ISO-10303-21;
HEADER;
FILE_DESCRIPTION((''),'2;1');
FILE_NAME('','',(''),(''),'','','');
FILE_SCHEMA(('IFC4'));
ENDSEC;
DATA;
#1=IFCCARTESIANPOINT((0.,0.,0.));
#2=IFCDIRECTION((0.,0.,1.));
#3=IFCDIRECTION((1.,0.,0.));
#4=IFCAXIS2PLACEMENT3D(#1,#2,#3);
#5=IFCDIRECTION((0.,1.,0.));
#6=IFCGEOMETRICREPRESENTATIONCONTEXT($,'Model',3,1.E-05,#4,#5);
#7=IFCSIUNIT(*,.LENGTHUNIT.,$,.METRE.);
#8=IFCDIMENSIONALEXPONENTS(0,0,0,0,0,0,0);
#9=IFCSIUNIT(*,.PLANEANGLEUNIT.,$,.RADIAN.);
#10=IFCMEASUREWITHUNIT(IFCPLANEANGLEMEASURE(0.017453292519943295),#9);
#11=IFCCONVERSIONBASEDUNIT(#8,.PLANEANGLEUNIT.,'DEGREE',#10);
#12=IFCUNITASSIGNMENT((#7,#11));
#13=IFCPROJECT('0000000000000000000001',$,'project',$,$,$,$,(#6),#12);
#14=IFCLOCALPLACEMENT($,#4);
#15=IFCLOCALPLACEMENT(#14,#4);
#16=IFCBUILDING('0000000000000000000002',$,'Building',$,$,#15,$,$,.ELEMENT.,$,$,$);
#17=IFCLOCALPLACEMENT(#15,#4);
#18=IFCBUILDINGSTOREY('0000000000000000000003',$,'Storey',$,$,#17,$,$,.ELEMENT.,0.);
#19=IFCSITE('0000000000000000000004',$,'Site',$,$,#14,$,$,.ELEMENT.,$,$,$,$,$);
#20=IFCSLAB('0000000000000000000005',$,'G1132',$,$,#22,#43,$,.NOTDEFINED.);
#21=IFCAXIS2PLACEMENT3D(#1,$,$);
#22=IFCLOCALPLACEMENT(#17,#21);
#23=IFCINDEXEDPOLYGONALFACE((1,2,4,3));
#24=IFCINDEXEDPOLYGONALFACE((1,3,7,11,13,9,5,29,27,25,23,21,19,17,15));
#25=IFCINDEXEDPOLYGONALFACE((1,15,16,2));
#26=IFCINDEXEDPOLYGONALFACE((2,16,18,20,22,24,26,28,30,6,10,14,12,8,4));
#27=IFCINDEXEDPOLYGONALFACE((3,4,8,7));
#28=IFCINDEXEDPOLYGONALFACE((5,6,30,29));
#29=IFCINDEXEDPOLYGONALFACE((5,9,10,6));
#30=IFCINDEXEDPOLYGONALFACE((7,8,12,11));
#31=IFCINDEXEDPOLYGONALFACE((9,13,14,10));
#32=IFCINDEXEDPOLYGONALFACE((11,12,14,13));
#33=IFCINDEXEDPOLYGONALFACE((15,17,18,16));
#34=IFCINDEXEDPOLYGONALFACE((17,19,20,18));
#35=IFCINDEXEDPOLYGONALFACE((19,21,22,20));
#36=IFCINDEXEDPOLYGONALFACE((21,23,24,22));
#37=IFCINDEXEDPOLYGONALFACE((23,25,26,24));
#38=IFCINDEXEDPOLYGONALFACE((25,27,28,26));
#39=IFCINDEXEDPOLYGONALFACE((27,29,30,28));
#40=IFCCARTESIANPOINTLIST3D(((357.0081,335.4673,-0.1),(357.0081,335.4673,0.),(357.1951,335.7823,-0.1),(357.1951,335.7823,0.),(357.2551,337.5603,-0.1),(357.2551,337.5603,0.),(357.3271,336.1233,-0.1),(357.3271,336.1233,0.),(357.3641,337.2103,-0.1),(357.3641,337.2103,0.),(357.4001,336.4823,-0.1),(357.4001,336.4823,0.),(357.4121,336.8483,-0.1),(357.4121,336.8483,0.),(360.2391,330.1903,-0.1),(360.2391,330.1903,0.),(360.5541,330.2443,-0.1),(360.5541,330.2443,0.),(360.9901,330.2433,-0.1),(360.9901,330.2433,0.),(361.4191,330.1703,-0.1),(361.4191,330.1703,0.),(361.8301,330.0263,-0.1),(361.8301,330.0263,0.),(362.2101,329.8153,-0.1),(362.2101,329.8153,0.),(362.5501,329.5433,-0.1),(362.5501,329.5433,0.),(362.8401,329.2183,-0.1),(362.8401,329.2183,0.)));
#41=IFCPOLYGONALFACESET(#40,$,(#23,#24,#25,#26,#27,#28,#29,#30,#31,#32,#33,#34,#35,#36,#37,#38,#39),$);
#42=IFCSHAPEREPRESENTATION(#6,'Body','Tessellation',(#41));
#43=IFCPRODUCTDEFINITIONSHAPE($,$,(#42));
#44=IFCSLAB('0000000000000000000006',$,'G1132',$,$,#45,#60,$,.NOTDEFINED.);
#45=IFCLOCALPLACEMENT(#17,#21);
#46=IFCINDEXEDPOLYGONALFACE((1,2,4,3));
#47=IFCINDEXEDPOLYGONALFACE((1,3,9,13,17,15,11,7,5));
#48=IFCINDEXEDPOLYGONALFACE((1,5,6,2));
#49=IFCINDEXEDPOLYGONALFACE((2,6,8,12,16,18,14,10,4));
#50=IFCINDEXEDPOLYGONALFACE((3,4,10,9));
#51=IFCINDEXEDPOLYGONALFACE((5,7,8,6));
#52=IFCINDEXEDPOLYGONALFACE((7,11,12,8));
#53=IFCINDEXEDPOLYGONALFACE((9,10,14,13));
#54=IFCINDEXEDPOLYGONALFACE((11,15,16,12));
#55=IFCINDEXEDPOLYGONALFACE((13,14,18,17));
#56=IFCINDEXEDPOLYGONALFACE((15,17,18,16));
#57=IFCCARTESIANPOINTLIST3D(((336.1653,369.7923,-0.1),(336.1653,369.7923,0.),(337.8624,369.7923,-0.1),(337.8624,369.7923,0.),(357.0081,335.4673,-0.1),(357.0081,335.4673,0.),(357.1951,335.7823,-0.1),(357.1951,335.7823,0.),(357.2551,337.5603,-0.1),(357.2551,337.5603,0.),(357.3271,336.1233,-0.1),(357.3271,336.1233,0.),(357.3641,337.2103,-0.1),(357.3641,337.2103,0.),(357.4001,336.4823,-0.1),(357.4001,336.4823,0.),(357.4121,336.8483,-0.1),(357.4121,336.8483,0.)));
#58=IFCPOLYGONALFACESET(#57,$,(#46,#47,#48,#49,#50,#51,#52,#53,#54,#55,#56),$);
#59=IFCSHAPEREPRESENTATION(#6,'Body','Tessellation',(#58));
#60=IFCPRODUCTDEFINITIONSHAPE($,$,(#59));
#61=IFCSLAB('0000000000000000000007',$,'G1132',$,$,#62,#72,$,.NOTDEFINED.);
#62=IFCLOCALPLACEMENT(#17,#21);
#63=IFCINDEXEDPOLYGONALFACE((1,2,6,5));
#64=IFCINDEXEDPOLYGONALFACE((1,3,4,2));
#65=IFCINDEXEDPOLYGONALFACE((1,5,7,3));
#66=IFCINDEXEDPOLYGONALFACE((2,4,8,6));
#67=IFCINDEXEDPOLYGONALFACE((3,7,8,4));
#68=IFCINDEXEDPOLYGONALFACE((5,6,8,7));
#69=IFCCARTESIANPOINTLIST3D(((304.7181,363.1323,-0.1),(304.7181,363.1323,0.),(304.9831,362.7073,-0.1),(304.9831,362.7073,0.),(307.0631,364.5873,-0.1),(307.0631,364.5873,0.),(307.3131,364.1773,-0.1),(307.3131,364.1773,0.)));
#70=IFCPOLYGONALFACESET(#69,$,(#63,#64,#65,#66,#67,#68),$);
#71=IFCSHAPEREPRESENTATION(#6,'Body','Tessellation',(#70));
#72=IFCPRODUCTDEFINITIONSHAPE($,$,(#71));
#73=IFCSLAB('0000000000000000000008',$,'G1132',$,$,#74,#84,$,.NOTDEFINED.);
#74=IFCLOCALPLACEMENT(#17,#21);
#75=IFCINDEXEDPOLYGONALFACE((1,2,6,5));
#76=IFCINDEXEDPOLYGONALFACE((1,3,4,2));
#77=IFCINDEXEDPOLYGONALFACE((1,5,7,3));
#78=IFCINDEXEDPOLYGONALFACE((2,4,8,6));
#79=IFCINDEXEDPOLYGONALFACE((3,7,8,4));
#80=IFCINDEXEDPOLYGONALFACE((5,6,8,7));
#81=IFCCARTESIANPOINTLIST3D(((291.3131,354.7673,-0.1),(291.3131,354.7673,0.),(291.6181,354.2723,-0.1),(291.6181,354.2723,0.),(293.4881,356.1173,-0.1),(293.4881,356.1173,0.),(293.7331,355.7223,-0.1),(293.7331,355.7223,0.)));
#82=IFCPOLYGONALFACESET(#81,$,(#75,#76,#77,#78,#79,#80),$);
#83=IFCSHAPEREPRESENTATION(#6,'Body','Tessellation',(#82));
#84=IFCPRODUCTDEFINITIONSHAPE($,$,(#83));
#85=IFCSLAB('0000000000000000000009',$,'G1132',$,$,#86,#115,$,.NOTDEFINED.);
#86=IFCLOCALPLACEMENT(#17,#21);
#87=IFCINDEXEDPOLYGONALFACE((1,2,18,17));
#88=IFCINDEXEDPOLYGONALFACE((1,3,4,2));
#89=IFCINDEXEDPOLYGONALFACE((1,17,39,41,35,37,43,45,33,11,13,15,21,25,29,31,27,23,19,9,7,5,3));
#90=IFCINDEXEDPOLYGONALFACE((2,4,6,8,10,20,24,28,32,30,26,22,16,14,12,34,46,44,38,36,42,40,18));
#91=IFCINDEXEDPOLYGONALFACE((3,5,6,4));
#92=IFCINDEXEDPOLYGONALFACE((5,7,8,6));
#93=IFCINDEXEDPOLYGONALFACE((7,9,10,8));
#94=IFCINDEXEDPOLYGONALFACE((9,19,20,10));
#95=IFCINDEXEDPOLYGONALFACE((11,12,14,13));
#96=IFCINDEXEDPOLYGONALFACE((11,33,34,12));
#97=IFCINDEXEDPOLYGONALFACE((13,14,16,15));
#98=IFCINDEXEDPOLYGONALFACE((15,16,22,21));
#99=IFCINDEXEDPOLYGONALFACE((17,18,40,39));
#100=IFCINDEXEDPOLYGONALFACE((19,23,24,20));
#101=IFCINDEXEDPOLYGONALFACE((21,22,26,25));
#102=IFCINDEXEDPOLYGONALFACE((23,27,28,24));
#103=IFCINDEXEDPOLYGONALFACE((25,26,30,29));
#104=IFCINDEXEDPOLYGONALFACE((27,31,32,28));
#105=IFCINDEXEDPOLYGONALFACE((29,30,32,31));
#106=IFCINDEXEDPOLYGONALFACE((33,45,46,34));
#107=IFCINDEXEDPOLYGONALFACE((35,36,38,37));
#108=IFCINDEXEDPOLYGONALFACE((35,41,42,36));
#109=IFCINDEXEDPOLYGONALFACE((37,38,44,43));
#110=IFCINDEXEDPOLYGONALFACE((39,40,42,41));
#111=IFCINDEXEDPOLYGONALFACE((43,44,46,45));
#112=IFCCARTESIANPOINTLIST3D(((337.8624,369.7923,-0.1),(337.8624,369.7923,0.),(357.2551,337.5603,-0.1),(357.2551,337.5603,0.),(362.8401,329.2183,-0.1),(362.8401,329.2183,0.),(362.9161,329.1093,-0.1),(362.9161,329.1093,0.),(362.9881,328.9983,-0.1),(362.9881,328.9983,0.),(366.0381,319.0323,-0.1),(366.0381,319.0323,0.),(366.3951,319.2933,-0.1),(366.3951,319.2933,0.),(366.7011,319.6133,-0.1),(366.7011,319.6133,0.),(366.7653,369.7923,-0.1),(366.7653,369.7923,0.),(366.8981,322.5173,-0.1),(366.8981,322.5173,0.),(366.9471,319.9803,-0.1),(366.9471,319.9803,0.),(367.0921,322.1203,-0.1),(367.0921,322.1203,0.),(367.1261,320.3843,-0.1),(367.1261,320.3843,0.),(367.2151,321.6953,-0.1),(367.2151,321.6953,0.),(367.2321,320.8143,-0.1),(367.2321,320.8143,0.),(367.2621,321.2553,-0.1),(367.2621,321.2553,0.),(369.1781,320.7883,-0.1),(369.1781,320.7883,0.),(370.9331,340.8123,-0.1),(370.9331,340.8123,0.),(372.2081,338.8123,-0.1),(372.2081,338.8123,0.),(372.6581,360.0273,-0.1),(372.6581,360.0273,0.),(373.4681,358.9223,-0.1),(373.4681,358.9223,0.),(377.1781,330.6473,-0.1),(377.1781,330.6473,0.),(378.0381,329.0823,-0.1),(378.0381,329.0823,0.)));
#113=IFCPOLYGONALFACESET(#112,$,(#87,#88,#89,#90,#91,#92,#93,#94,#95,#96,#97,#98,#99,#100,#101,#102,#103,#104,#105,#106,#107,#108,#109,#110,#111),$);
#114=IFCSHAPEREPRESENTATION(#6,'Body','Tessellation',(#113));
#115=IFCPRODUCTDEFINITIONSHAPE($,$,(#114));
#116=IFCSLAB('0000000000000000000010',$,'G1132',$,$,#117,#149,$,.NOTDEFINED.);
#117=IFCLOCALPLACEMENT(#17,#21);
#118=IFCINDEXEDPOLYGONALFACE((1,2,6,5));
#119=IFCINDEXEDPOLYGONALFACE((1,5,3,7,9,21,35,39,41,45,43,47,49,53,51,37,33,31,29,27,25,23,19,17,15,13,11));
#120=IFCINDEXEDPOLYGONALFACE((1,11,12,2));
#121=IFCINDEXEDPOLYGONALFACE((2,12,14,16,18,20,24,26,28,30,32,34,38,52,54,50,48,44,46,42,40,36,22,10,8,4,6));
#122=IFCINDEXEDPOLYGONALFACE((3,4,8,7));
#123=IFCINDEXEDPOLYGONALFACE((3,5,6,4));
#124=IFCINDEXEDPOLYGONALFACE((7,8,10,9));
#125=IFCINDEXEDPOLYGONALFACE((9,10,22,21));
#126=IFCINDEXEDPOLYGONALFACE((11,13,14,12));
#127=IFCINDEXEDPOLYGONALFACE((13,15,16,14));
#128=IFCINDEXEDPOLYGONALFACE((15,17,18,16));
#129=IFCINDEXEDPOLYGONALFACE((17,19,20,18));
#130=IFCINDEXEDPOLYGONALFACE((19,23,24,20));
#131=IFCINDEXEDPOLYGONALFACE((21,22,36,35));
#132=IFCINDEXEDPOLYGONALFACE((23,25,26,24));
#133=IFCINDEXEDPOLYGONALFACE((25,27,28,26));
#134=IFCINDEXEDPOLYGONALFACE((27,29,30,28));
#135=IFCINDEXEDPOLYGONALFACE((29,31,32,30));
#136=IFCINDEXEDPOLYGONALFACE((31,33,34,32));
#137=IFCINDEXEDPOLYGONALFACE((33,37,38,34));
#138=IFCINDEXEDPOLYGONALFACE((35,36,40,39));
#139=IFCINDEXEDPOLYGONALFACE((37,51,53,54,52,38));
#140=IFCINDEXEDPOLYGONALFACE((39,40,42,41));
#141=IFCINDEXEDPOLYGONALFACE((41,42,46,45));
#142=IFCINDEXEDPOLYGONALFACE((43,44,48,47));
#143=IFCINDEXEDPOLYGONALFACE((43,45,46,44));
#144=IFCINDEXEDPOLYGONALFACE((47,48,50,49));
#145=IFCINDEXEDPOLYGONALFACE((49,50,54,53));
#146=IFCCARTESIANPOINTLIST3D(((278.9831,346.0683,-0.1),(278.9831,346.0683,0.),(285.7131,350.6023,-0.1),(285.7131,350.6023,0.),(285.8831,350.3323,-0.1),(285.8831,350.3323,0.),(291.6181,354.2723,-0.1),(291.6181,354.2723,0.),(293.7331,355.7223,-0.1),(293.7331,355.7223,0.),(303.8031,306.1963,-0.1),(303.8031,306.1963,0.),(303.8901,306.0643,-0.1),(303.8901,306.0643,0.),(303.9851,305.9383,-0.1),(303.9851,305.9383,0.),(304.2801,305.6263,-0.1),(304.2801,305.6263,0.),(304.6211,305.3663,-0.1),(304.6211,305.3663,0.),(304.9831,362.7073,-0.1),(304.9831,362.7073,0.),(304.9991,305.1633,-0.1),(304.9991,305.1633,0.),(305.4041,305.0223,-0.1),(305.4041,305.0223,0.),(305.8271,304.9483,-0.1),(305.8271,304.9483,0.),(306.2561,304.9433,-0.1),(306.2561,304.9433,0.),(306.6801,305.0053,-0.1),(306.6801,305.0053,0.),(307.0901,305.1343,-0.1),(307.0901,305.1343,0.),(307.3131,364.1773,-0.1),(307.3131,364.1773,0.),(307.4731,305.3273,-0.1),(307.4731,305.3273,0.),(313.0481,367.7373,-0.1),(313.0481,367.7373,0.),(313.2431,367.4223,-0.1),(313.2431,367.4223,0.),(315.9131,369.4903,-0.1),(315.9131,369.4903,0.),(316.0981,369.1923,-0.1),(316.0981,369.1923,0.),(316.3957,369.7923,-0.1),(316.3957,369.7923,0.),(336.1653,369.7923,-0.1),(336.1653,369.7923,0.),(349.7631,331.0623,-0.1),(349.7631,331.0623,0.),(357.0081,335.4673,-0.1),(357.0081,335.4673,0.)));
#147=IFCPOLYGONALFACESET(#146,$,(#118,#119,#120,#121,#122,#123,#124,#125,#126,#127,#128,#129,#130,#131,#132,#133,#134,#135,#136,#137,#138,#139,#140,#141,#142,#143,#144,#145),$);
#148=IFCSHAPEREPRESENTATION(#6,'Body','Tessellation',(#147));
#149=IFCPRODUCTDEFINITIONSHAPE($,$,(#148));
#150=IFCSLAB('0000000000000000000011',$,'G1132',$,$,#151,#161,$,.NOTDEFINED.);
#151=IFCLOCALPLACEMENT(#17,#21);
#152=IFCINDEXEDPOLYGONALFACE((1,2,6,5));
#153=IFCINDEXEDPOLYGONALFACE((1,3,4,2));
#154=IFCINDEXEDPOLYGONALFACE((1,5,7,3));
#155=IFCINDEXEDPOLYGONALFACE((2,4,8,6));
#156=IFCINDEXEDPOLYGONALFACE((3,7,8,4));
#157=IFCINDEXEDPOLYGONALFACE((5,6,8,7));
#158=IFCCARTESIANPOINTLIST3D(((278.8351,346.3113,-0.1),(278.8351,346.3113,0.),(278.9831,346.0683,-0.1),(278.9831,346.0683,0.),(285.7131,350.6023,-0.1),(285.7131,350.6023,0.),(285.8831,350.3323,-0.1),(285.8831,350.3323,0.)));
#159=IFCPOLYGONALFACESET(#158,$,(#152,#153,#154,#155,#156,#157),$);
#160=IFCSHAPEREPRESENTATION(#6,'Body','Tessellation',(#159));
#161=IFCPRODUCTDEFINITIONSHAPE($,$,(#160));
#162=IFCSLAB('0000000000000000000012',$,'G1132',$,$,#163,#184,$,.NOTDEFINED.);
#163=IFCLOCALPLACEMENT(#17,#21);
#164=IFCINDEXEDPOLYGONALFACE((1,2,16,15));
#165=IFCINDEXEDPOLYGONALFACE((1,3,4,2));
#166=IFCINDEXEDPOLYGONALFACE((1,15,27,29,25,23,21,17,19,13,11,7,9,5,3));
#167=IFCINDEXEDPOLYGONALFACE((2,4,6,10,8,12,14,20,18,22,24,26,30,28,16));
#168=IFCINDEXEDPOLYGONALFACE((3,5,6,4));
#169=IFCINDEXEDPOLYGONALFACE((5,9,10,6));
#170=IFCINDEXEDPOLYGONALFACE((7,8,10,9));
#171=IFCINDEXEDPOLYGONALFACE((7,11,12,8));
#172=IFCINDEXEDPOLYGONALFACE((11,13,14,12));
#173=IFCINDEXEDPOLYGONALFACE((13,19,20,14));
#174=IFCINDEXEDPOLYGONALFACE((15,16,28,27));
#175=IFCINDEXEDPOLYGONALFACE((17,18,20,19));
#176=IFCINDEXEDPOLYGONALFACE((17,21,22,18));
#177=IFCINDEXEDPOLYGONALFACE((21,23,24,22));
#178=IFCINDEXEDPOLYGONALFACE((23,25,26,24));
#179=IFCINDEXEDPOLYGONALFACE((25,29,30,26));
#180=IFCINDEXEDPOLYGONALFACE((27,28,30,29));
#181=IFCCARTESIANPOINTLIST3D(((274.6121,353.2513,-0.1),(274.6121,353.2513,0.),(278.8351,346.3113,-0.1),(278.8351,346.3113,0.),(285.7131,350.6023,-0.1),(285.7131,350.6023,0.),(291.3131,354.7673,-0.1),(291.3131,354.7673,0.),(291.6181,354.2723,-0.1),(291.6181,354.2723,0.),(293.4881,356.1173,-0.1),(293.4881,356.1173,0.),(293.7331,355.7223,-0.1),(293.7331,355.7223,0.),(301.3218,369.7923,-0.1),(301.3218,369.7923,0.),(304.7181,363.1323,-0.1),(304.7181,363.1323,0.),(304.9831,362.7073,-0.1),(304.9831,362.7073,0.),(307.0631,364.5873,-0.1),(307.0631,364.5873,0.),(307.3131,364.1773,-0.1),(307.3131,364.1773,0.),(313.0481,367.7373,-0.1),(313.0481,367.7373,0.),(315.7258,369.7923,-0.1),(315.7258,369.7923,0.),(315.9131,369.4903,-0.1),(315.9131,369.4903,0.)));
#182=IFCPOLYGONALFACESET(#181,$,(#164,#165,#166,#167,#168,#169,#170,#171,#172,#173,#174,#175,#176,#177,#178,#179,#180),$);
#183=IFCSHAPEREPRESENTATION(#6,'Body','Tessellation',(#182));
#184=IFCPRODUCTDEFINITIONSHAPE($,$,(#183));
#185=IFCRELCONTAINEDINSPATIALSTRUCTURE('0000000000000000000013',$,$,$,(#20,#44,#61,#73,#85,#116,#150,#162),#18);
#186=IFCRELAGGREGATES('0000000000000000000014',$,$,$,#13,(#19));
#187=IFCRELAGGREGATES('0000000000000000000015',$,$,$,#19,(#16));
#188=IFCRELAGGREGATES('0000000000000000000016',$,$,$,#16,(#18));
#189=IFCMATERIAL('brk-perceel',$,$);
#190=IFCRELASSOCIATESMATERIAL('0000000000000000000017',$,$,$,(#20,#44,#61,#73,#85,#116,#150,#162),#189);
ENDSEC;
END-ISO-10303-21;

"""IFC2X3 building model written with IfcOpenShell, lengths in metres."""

from ifc_helpers import new_model, entity, si_unit, converted_unit, direction, frame, origin_with_axes, place, context, project, spatial, polyline, outline, extrude, material, element, save


model = new_model("IFC2X3")

# Units and contexts
model_context = context("Model", 3, precision=1e-05, world=origin_with_axes(), true_north=direction((0.0, 1.0, 0.0)))
ifc_project = project(units=[si_unit("LENGTHUNIT", "METRE"), converted_unit("PLANEANGLEUNIT", "DEGREE", entity("IfcPlaneAngleMeasure", 0.017453292519943295), si_unit("PLANEANGLEUNIT", "RADIAN"), dimensions=[0, 0, 0, 0, 0, 0, 0])], contexts=[model_context])

# Site, building, storey
site_placement = place(None, origin_with_axes())
site = spatial("IfcSite", under=ifc_project, at=site_placement, Name="Site", CompositionType="ELEMENT")
building_placement = place(site_placement, origin_with_axes())
building = spatial("IfcBuilding", under=site, at=building_placement, Name="Building", CompositionType="ELEMENT")
storey_placement = place(building_placement, origin_with_axes())
storey = spatial("IfcBuildingStorey", under=building, at=storey_placement, Name="Storey", CompositionType="ELEMENT", Elevation=0.0)

# Slabs
ifc_material_1 = material(Name="brk-perceel")
slab_1_placement = place(storey_placement, frame((0.0, 0.0, -0.1), z_axis=(0.0, 0.0, 1.0), x_axis=(1.0, 0.0, 0.0)))
element("IfcSlab", 1, at=slab_1_placement, inside=storey, material=ifc_material_1, Name="G1132", PredefinedType="NOTDEFINED", context=model_context, shape_type="SweptSolid", body=[
    extrude(outline(polyline([(357.1951, 335.7823), (357.3271, 336.1233), (357.4001, 336.4823), (357.4121, 336.8483), (357.3641, 337.2103), (357.2551, 337.5603), (362.8401, 329.2183), (362.5501, 329.5433), (362.2101, 329.8153), (361.8301, 330.0263), (361.4191, 330.1703), (360.9901, 330.2433), (360.5541, 330.2443), (360.2391, 330.1903), (357.0081, 335.4673), (357.1951, 335.7823)])), origin_with_axes(), (0.0, 0.0, 1.0), 0.1),
])
slab_2_placement = place(storey_placement, frame((0.0, 0.0, -0.1), z_axis=(0.0, 0.0, 1.0), x_axis=(1.0, 0.0, 0.0)))
element("IfcSlab", 2, at=slab_2_placement, inside=storey, material=ifc_material_1, Name="G1132", PredefinedType="NOTDEFINED", context=model_context, shape_type="SweptSolid", body=[
    extrude(outline(polyline([(357.2551, 337.5603), (357.3641, 337.2103), (357.4121, 336.8483), (357.4001, 336.4823), (357.3271, 336.1233), (357.1951, 335.7823), (357.0081, 335.4673), (336.1653, 369.7923), (337.8624, 369.7923), (357.2551, 337.5603)])), origin_with_axes(), (0.0, 0.0, 1.0), 0.1),
])
slab_3_placement = place(storey_placement, frame((0.0, 0.0, -0.1), z_axis=(0.0, 0.0, 1.0), x_axis=(1.0, 0.0, 0.0)))
element("IfcSlab", 3, at=slab_3_placement, inside=storey, material=ifc_material_1, Name="G1132", PredefinedType="NOTDEFINED", context=model_context, shape_type="SweptSolid", body=[
    extrude(outline(polyline([(304.7181, 363.1323), (307.0631, 364.5873), (307.3131, 364.1773), (304.9831, 362.7073), (304.7181, 363.1323)])), origin_with_axes(), (0.0, 0.0, 1.0), 0.1),
])
slab_4_placement = place(storey_placement, frame((0.0, 0.0, -0.1), z_axis=(0.0, 0.0, 1.0), x_axis=(1.0, 0.0, 0.0)))
element("IfcSlab", 4, at=slab_4_placement, inside=storey, material=ifc_material_1, Name="G1132", PredefinedType="NOTDEFINED", context=model_context, shape_type="SweptSolid", body=[
    extrude(outline(polyline([(291.3131, 354.7673), (293.4881, 356.1173), (293.7331, 355.7223), (291.6181, 354.2723), (291.3131, 354.7673)])), origin_with_axes(), (0.0, 0.0, 1.0), 0.1),
])
slab_5_placement = place(storey_placement, frame((0.0, 0.0, -0.1), z_axis=(0.0, 0.0, 1.0), x_axis=(1.0, 0.0, 0.0)))
element("IfcSlab", 5, at=slab_5_placement, inside=storey, material=ifc_material_1, Name="G1132", PredefinedType="NOTDEFINED", context=model_context, shape_type="SweptSolid", body=[
    extrude(outline(polyline([(372.6581, 360.0273), (373.4681, 358.9223), (370.9331, 340.8123), (372.2081, 338.8123), (377.1781, 330.6473), (378.0381, 329.0823), (369.1781, 320.7883), (366.0381, 319.0323), (366.3951, 319.2933), (366.7011, 319.6133), (366.9471, 319.9803), (367.1261, 320.3843), (367.2321, 320.8143), (367.2621, 321.2553), (367.2151, 321.6953), (367.0921, 322.1203), (366.8981, 322.5173), (362.9881, 328.9983), (362.9161, 329.1093), (362.8401, 329.2183), (357.2551, 337.5603), (337.8624, 369.7923), (366.7653, 369.7923), (372.6581, 360.0273)])), origin_with_axes(), (0.0, 0.0, 1.0), 0.1),
])
slab_6_placement = place(storey_placement, frame((0.0, 0.0, -0.1), z_axis=(0.0, 0.0, 1.0), x_axis=(1.0, 0.0, 0.0)))
element("IfcSlab", 6, at=slab_6_placement, inside=storey, material=ifc_material_1, Name="G1132", PredefinedType="NOTDEFINED", context=model_context, shape_type="SweptSolid", body=[
    extrude(outline(polyline([(357.0081, 335.4673), (349.7631, 331.0623), (307.4731, 305.3273), (307.0901, 305.1343), (306.6801, 305.0053), (306.2561, 304.9433), (305.8271, 304.9483), (305.4041, 305.0223), (304.9991, 305.1633), (304.6211, 305.3663), (304.2801, 305.6263), (303.9851, 305.9383), (303.8901, 306.0643), (303.8031, 306.1963), (278.9831, 346.0683), (285.8831, 350.3323), (285.7131, 350.6023), (291.6181, 354.2723), (293.7331, 355.7223), (304.9831, 362.7073), (307.3131, 364.1773), (313.0481, 367.7373), (313.2431, 367.4223), (316.0981, 369.1923), (315.9131, 369.4903), (316.3957, 369.7923), (336.1653, 369.7923), (357.0081, 335.4673)])), origin_with_axes(), (0.0, 0.0, 1.0), 0.1),
])
slab_7_placement = place(storey_placement, frame((0.0, 0.0, -0.1), z_axis=(0.0, 0.0, 1.0), x_axis=(1.0, 0.0, 0.0)))
element("IfcSlab", 7, at=slab_7_placement, inside=storey, material=ifc_material_1, Name="G1132", PredefinedType="NOTDEFINED", context=model_context, shape_type="SweptSolid", body=[
    extrude(outline(polyline([(285.7131, 350.6023), (285.8831, 350.3323), (278.9831, 346.0683), (278.8351, 346.3113), (285.7131, 350.6023)])), origin_with_axes(), (0.0, 0.0, 1.0), 0.1),
])
slab_8_placement = place(storey_placement, frame((0.0, 0.0, -0.1), z_axis=(0.0, 0.0, 1.0), x_axis=(1.0, 0.0, 0.0)))
element("IfcSlab", 8, at=slab_8_placement, inside=storey, material=ifc_material_1, Name="G1132", PredefinedType="NOTDEFINED", context=model_context, shape_type="SweptSolid", body=[
    extrude(outline(polyline([(315.9131, 369.4903), (313.0481, 367.7373), (307.3131, 364.1773), (307.0631, 364.5873), (304.7181, 363.1323), (304.9831, 362.7073), (293.7331, 355.7223), (293.4881, 356.1173), (291.3131, 354.7673), (291.6181, 354.2723), (285.7131, 350.6023), (278.8351, 346.3113), (274.6121, 353.2513), (301.3218, 369.7923), (315.7258, 369.7923), (315.9131, 369.4903)])), origin_with_axes(), (0.0, 0.0, 1.0), 0.1),
])

save(model, "model.ifc")
